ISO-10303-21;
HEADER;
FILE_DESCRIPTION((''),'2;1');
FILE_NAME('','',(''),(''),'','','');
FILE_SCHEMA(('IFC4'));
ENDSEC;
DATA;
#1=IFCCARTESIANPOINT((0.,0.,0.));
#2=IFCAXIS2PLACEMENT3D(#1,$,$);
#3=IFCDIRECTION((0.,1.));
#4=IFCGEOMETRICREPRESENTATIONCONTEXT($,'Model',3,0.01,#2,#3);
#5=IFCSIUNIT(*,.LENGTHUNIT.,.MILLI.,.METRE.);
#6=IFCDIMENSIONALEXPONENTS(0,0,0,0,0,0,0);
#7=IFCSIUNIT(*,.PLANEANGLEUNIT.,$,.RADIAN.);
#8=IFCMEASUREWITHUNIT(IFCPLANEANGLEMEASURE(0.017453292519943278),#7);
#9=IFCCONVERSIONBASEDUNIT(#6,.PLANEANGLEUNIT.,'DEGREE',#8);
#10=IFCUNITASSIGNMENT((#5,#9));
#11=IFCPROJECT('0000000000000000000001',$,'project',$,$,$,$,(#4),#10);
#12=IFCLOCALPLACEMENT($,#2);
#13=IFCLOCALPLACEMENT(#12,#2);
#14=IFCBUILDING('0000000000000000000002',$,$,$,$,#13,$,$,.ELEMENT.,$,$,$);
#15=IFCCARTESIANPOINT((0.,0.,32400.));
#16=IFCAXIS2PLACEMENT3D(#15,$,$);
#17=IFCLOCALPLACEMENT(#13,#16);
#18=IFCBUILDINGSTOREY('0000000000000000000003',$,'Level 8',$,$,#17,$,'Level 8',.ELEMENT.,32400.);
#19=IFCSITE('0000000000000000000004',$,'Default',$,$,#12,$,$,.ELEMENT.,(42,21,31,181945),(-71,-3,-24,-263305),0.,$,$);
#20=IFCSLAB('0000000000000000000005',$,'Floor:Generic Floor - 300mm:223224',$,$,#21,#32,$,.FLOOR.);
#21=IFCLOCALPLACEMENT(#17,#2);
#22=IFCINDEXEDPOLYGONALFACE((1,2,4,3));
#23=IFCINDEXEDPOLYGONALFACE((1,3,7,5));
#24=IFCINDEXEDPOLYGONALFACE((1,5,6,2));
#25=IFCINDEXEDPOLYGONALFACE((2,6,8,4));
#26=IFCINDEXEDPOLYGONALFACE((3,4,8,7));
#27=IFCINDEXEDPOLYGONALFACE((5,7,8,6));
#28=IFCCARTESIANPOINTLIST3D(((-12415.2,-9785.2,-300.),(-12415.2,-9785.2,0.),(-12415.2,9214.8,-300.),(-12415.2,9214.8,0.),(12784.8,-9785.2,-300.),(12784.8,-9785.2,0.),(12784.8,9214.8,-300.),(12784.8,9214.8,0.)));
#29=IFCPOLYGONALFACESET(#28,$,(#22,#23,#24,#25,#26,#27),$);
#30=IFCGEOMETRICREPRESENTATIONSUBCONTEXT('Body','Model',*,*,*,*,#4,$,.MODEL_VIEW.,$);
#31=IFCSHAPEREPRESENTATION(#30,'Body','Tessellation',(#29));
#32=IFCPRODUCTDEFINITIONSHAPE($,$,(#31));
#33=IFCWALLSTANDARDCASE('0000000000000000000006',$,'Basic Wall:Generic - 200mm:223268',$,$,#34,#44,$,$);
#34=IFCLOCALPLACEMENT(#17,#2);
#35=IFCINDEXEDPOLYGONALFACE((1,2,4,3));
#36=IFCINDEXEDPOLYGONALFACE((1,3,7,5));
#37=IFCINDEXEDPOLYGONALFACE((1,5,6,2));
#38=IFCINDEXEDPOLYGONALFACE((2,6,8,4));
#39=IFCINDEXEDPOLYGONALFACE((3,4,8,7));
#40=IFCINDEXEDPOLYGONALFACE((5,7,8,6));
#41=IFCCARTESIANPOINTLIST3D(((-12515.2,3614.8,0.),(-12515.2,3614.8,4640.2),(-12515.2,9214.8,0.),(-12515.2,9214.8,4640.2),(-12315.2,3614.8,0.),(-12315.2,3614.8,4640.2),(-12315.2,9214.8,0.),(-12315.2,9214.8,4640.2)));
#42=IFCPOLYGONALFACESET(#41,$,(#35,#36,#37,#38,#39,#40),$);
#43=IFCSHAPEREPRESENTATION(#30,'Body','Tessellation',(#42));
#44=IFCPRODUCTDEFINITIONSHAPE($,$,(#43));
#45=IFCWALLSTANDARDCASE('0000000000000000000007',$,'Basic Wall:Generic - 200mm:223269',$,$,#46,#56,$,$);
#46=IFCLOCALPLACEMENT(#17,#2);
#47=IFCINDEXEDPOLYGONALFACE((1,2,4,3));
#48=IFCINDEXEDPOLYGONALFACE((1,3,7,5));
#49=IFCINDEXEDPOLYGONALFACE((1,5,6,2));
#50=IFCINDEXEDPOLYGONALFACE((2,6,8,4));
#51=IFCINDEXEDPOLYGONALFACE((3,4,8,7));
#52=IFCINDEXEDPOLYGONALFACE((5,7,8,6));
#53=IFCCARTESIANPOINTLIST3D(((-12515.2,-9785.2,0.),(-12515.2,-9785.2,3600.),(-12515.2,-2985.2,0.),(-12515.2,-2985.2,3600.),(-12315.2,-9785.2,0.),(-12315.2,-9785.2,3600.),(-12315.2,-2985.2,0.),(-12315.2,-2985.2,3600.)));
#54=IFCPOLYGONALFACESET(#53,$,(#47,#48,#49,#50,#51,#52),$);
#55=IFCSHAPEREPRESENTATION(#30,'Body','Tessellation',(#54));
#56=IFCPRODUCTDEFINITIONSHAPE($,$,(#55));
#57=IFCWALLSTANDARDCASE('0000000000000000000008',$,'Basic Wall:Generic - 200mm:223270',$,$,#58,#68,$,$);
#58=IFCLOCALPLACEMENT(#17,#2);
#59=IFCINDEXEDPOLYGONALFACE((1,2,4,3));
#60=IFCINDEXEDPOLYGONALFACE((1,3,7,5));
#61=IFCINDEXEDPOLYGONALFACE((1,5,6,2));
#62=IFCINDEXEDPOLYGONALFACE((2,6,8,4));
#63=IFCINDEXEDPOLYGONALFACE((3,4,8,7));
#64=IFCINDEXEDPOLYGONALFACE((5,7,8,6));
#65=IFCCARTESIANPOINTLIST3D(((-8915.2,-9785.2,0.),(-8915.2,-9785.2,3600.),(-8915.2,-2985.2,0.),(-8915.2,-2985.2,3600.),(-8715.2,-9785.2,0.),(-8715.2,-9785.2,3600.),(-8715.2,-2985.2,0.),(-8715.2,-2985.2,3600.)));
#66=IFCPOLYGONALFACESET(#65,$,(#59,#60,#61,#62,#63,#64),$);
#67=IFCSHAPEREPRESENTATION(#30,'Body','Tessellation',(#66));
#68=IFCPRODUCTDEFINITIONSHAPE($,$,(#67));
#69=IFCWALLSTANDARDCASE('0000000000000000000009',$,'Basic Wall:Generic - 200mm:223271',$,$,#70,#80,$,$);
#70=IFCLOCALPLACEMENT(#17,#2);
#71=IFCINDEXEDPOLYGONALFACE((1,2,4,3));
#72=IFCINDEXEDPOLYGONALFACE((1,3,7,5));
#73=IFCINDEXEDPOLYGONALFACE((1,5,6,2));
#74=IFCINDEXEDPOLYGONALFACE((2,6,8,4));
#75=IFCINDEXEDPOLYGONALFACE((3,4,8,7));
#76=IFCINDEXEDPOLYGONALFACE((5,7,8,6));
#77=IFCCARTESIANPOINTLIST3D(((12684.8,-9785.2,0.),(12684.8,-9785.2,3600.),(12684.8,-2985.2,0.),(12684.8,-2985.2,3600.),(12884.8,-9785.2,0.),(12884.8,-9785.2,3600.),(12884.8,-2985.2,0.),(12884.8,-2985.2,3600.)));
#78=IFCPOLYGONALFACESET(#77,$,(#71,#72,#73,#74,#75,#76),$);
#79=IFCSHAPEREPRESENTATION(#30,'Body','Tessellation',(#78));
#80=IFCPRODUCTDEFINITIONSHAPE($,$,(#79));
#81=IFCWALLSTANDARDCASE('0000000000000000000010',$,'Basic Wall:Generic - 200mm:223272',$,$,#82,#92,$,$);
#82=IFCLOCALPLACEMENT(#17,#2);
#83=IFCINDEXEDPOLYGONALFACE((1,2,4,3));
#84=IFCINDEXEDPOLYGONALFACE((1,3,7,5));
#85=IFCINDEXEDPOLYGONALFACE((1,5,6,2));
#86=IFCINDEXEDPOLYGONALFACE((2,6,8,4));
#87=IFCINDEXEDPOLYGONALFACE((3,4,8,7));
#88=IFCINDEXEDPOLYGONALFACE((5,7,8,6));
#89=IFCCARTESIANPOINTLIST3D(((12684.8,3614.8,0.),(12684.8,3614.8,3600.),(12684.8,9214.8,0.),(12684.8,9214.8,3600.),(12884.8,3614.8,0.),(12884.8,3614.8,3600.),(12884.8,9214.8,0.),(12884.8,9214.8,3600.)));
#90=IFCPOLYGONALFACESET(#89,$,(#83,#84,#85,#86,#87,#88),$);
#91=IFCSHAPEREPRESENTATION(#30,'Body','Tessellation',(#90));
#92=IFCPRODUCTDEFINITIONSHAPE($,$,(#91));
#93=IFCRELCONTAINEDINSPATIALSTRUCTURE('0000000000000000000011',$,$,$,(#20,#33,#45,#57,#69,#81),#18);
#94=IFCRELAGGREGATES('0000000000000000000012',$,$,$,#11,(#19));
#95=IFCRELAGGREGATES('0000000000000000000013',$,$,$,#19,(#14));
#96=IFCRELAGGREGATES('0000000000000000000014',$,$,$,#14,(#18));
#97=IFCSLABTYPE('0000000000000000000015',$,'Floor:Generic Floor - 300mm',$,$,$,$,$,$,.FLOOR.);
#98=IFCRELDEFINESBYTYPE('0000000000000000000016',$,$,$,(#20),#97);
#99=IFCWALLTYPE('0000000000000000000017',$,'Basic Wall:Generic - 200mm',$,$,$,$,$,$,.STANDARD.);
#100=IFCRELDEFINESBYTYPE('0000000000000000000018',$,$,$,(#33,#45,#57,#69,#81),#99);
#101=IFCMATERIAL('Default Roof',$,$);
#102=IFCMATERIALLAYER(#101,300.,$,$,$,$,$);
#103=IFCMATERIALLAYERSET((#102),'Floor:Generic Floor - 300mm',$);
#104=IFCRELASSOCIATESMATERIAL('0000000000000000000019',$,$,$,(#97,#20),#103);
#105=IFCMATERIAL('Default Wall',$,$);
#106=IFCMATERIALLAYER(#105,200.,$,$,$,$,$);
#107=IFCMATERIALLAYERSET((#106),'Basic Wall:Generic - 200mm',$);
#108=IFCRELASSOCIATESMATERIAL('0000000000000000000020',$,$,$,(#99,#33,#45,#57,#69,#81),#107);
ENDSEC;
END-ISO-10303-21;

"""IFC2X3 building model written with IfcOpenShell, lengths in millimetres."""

from ifc_helpers import new_model, entity, si_unit, converted_unit, direction, frame, frame_2d, origin, origin_2d_with_axis, place, context, subcontext, project, spatial, rectangle, extrude, material, layer, layer_set, layer_usage, type_object, element, save


model = new_model("IFC2X3")

# Units and contexts
model_context = context("Model", 3, precision=0.01, world=origin(), true_north=direction((0.0, 1.0)))
body_context = subcontext(model_context, "Body", "Model", "MODEL_VIEW")
ifc_project = project(units=[si_unit("LENGTHUNIT", "METRE", prefix="MILLI"), converted_unit("PLANEANGLEUNIT", "DEGREE", entity("IfcPlaneAngleMeasure", 0.017453292519943278), si_unit("PLANEANGLEUNIT", "RADIAN"), dimensions=[0, 0, 0, 0, 0, 0, 0])], contexts=[model_context])

# Site, building, storey
site_placement = place(None, origin())
site = spatial("IfcSite", under=ifc_project, at=site_placement, Name="Default", CompositionType="ELEMENT", RefLatitude=(42, 21, 31, 181945), RefLongitude=(-71, -3, -24, -263305), RefElevation=0.0)
building_placement = place(site_placement, origin())
building = spatial("IfcBuilding", under=site, at=building_placement, CompositionType="ELEMENT")
storey_placement = place(building_placement, frame((0.0, 0.0, 32400.0)))
storey = spatial("IfcBuildingStorey", under=building, at=storey_placement, Name="Level 8", LongName="Level 8", CompositionType="ELEMENT", Elevation=32400.0)

# Slab
ifc_material_1 = material(Name="Default Roof")
ifc_layer_1 = layer(ifc_material_1, 300.0)
ifc_layer_set_1 = layer_set([ifc_layer_1], Name="Floor:Generic Floor - 300mm")
ifc_layer_usage_1 = layer_usage(ifc_layer_set_1, "AXIS3", "POSITIVE", 0.0)
slab_type = type_object("IfcSlabType", Name="Floor:Generic Floor - 300mm", PredefinedType="FLOOR", material=ifc_layer_set_1)
slab_placement = place(storey_placement, origin())
element("IfcSlab", 1, at=slab_placement, inside=storey, type_object=slab_type, material=ifc_layer_usage_1, Name="Floor:Generic Floor - 300mm:223224", PredefinedType="FLOOR", context=body_context, shape_type="SweptSolid", body=[
    extrude(rectangle(XDim=19000.0, YDim=25200.0, at=origin_2d_with_axis()), frame((184.8, -285.2, 0.0), z_axis=(0.0, 0.0, -1.0), x_axis=(0.0, 1.0, 0.0)), (0.0, 0.0, 1.0), 300.0),
])

# Walls
ifc_material_2 = material(Name="Default Wall")
ifc_layer_2 = layer(ifc_material_2, 200.0)
ifc_layer_set_2 = layer_set([ifc_layer_2], Name="Basic Wall:Generic - 200mm")
ifc_layer_usage_2 = layer_usage(ifc_layer_set_2, "AXIS2", "NEGATIVE", 100.0)
wall_type = type_object("IfcWallType", Name="Basic Wall:Generic - 200mm", PredefinedType="STANDARD", material=ifc_layer_set_2)
wall_1_placement = place(storey_placement, frame((-12415.2, 3614.8, 0.0), z_axis=(0.0, 0.0, 1.0), x_axis=(0.0, 1.0, 0.0)))
element("IfcWallStandardCase", 2, at=wall_1_placement, inside=storey, type_object=wall_type, material=ifc_layer_usage_2, Name="Basic Wall:Generic - 200mm:223268", context=body_context, shape_type="SweptSolid", body=[
    extrude(rectangle(XDim=5600.0, YDim=200.0, at=frame_2d((2800.0, 0.0), x_axis=(-1.0, 0.0))), origin(), (0.0, 0.0, 1.0), 4640.2),
])
ifc_layer_usage_3 = layer_usage(ifc_layer_set_2, "AXIS2", "NEGATIVE", 100.0)
wall_2_placement = place(storey_placement, frame((-12415.2, -9785.2, 0.0), z_axis=(0.0, 0.0, 1.0), x_axis=(0.0, 1.0, 0.0)))
element("IfcWallStandardCase", 3, at=wall_2_placement, inside=storey, type_object=wall_type, material=ifc_layer_usage_3, Name="Basic Wall:Generic - 200mm:223269", context=body_context, shape_type="SweptSolid", body=[
    extrude(rectangle(XDim=6800.0, YDim=200.0, at=frame_2d((3400.0, 0.0), x_axis=(-1.0, 0.0))), origin(), (0.0, 0.0, 1.0), 3600.0),
])
ifc_layer_usage_4 = layer_usage(ifc_layer_set_2, "AXIS2", "NEGATIVE", 100.0)
wall_3_placement = place(storey_placement, frame((-8815.2, -9785.2, 0.0), z_axis=(0.0, 0.0, 1.0), x_axis=(0.0, 1.0, 0.0)))
element("IfcWallStandardCase", 4, at=wall_3_placement, inside=storey, type_object=wall_type, material=ifc_layer_usage_4, Name="Basic Wall:Generic - 200mm:223270", context=body_context, shape_type="SweptSolid", body=[
    extrude(rectangle(XDim=6800.0, YDim=200.0, at=frame_2d((3400.0, 0.0), x_axis=(-1.0, 0.0))), origin(), (0.0, 0.0, 1.0), 3600.0),
])
ifc_layer_usage_5 = layer_usage(ifc_layer_set_2, "AXIS2", "NEGATIVE", 100.0)
wall_4_placement = place(storey_placement, frame((12784.8, -9785.2, 0.0), z_axis=(0.0, 0.0, 1.0), x_axis=(0.0, 1.0, 0.0)))
element("IfcWallStandardCase", 5, at=wall_4_placement, inside=storey, type_object=wall_type, material=ifc_layer_usage_5, Name="Basic Wall:Generic - 200mm:223271", context=body_context, shape_type="SweptSolid", body=[
    extrude(rectangle(XDim=6800.0, YDim=200.0, at=frame_2d((3400.0, 0.0), x_axis=(-1.0, 0.0))), origin(), (0.0, 0.0, 1.0), 3600.0),
])
ifc_layer_usage_6 = layer_usage(ifc_layer_set_2, "AXIS2", "NEGATIVE", 100.0)
wall_5_placement = place(storey_placement, frame((12784.8, 3614.8, 0.0), z_axis=(0.0, 0.0, 1.0), x_axis=(0.0, 1.0, 0.0)))
element("IfcWallStandardCase", 6, at=wall_5_placement, inside=storey, type_object=wall_type, material=ifc_layer_usage_6, Name="Basic Wall:Generic - 200mm:223272", context=body_context, shape_type="SweptSolid", body=[
    extrude(rectangle(XDim=5600.0, YDim=200.0, at=frame_2d((2800.0, 0.0), x_axis=(-1.0, 0.0))), origin(), (0.0, 0.0, 1.0), 3600.0),
])

save(model, "model.ifc")
